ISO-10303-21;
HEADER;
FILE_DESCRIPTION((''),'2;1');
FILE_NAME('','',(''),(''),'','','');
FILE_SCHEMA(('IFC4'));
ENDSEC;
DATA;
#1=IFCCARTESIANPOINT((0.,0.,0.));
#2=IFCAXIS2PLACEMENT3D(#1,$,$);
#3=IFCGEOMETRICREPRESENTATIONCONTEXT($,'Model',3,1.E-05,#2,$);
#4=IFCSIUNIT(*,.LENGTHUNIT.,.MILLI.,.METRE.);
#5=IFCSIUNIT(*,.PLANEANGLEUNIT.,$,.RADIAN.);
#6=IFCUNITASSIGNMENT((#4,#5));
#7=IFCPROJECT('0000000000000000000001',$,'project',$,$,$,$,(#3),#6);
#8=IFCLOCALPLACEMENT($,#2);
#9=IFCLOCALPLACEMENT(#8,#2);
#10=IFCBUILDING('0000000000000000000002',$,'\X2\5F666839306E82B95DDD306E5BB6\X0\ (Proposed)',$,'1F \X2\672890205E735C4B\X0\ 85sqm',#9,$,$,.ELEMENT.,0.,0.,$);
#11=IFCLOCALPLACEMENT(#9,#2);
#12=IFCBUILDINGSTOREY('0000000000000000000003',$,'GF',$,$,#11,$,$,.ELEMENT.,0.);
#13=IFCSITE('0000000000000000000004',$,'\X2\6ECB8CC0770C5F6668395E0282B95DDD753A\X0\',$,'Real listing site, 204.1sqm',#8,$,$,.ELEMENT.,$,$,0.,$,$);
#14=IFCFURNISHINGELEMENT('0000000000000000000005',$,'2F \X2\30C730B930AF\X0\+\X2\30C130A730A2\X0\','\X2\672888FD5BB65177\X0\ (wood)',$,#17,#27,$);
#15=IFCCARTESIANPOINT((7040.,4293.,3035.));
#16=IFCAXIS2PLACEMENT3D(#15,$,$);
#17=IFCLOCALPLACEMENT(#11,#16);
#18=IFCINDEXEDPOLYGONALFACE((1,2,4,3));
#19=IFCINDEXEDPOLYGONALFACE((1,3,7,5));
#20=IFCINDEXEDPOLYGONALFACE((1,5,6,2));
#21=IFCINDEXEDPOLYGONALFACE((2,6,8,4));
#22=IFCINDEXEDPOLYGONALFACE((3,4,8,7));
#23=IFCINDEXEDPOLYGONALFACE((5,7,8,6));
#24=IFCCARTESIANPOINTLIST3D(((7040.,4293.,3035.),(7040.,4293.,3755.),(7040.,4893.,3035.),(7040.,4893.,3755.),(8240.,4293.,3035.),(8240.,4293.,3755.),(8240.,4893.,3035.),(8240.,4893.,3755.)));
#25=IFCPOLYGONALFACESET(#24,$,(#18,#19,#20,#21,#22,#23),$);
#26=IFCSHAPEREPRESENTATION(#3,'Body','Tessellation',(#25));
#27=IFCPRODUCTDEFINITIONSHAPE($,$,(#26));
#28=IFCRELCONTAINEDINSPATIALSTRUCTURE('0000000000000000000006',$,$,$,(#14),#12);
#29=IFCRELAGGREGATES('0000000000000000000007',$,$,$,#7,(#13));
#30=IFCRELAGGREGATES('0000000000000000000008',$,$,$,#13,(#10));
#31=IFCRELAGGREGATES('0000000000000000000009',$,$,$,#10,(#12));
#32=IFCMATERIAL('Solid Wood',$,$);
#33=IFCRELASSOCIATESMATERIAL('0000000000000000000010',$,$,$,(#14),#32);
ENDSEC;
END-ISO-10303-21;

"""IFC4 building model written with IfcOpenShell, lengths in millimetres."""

from ifc_helpers import new_model, si_unit, frame, frame_2d, origin, place, context, project, spatial, rectangle, extrude, material, element, save


model = new_model("IFC4")

# Units and contexts
model_context = context("Model", 3, precision=1e-05, world=origin())
ifc_project = project(units=[si_unit("LENGTHUNIT", "METRE", prefix="MILLI"), si_unit("PLANEANGLEUNIT", "RADIAN")], contexts=[model_context])

# Site, building, storey
site_placement = place(None, origin())
site = spatial("IfcSite", under=ifc_project, at=site_placement, Name="滋賀県彦根市芹川町", ObjectType="Real listing site, 204.1sqm", CompositionType="ELEMENT", RefElevation=0.0)
building_placement = place(site_placement, origin())
building = spatial("IfcBuilding", under=site, at=building_placement, Name="彦根の芹川の家 (Proposed)", ObjectType="1F 木造平屋 85sqm", CompositionType="ELEMENT", ElevationOfRefHeight=0.0, ElevationOfTerrain=0.0)
storey_placement = place(building_placement, origin())
storey = spatial("IfcBuildingStorey", under=building, at=storey_placement, Name="GF", CompositionType="ELEMENT", Elevation=0.0)

# Shared definitions
ifc_material_1 = material(Name="Solid Wood")

# Furnishing element
furnishing_1_placement = place(storey_placement, frame((7040.0, 4293.0, 3035.0)))
element("IfcFurnishingElement", 1, at=furnishing_1_placement, inside=storey, material=ifc_material_1, Name="2F デスク+チェア", Description="木製家具 (wood)", context=model_context, shape_type="SweptSolid", body=[
    extrude(rectangle(XDim=1200.0, YDim=600.0, at=frame_2d((600.0, 300.0))), frame((7040.0, 4293.0, 3035.0)), (0.0, 0.0, 1.0), 720.0),
])

save(model, "model.ifc")
